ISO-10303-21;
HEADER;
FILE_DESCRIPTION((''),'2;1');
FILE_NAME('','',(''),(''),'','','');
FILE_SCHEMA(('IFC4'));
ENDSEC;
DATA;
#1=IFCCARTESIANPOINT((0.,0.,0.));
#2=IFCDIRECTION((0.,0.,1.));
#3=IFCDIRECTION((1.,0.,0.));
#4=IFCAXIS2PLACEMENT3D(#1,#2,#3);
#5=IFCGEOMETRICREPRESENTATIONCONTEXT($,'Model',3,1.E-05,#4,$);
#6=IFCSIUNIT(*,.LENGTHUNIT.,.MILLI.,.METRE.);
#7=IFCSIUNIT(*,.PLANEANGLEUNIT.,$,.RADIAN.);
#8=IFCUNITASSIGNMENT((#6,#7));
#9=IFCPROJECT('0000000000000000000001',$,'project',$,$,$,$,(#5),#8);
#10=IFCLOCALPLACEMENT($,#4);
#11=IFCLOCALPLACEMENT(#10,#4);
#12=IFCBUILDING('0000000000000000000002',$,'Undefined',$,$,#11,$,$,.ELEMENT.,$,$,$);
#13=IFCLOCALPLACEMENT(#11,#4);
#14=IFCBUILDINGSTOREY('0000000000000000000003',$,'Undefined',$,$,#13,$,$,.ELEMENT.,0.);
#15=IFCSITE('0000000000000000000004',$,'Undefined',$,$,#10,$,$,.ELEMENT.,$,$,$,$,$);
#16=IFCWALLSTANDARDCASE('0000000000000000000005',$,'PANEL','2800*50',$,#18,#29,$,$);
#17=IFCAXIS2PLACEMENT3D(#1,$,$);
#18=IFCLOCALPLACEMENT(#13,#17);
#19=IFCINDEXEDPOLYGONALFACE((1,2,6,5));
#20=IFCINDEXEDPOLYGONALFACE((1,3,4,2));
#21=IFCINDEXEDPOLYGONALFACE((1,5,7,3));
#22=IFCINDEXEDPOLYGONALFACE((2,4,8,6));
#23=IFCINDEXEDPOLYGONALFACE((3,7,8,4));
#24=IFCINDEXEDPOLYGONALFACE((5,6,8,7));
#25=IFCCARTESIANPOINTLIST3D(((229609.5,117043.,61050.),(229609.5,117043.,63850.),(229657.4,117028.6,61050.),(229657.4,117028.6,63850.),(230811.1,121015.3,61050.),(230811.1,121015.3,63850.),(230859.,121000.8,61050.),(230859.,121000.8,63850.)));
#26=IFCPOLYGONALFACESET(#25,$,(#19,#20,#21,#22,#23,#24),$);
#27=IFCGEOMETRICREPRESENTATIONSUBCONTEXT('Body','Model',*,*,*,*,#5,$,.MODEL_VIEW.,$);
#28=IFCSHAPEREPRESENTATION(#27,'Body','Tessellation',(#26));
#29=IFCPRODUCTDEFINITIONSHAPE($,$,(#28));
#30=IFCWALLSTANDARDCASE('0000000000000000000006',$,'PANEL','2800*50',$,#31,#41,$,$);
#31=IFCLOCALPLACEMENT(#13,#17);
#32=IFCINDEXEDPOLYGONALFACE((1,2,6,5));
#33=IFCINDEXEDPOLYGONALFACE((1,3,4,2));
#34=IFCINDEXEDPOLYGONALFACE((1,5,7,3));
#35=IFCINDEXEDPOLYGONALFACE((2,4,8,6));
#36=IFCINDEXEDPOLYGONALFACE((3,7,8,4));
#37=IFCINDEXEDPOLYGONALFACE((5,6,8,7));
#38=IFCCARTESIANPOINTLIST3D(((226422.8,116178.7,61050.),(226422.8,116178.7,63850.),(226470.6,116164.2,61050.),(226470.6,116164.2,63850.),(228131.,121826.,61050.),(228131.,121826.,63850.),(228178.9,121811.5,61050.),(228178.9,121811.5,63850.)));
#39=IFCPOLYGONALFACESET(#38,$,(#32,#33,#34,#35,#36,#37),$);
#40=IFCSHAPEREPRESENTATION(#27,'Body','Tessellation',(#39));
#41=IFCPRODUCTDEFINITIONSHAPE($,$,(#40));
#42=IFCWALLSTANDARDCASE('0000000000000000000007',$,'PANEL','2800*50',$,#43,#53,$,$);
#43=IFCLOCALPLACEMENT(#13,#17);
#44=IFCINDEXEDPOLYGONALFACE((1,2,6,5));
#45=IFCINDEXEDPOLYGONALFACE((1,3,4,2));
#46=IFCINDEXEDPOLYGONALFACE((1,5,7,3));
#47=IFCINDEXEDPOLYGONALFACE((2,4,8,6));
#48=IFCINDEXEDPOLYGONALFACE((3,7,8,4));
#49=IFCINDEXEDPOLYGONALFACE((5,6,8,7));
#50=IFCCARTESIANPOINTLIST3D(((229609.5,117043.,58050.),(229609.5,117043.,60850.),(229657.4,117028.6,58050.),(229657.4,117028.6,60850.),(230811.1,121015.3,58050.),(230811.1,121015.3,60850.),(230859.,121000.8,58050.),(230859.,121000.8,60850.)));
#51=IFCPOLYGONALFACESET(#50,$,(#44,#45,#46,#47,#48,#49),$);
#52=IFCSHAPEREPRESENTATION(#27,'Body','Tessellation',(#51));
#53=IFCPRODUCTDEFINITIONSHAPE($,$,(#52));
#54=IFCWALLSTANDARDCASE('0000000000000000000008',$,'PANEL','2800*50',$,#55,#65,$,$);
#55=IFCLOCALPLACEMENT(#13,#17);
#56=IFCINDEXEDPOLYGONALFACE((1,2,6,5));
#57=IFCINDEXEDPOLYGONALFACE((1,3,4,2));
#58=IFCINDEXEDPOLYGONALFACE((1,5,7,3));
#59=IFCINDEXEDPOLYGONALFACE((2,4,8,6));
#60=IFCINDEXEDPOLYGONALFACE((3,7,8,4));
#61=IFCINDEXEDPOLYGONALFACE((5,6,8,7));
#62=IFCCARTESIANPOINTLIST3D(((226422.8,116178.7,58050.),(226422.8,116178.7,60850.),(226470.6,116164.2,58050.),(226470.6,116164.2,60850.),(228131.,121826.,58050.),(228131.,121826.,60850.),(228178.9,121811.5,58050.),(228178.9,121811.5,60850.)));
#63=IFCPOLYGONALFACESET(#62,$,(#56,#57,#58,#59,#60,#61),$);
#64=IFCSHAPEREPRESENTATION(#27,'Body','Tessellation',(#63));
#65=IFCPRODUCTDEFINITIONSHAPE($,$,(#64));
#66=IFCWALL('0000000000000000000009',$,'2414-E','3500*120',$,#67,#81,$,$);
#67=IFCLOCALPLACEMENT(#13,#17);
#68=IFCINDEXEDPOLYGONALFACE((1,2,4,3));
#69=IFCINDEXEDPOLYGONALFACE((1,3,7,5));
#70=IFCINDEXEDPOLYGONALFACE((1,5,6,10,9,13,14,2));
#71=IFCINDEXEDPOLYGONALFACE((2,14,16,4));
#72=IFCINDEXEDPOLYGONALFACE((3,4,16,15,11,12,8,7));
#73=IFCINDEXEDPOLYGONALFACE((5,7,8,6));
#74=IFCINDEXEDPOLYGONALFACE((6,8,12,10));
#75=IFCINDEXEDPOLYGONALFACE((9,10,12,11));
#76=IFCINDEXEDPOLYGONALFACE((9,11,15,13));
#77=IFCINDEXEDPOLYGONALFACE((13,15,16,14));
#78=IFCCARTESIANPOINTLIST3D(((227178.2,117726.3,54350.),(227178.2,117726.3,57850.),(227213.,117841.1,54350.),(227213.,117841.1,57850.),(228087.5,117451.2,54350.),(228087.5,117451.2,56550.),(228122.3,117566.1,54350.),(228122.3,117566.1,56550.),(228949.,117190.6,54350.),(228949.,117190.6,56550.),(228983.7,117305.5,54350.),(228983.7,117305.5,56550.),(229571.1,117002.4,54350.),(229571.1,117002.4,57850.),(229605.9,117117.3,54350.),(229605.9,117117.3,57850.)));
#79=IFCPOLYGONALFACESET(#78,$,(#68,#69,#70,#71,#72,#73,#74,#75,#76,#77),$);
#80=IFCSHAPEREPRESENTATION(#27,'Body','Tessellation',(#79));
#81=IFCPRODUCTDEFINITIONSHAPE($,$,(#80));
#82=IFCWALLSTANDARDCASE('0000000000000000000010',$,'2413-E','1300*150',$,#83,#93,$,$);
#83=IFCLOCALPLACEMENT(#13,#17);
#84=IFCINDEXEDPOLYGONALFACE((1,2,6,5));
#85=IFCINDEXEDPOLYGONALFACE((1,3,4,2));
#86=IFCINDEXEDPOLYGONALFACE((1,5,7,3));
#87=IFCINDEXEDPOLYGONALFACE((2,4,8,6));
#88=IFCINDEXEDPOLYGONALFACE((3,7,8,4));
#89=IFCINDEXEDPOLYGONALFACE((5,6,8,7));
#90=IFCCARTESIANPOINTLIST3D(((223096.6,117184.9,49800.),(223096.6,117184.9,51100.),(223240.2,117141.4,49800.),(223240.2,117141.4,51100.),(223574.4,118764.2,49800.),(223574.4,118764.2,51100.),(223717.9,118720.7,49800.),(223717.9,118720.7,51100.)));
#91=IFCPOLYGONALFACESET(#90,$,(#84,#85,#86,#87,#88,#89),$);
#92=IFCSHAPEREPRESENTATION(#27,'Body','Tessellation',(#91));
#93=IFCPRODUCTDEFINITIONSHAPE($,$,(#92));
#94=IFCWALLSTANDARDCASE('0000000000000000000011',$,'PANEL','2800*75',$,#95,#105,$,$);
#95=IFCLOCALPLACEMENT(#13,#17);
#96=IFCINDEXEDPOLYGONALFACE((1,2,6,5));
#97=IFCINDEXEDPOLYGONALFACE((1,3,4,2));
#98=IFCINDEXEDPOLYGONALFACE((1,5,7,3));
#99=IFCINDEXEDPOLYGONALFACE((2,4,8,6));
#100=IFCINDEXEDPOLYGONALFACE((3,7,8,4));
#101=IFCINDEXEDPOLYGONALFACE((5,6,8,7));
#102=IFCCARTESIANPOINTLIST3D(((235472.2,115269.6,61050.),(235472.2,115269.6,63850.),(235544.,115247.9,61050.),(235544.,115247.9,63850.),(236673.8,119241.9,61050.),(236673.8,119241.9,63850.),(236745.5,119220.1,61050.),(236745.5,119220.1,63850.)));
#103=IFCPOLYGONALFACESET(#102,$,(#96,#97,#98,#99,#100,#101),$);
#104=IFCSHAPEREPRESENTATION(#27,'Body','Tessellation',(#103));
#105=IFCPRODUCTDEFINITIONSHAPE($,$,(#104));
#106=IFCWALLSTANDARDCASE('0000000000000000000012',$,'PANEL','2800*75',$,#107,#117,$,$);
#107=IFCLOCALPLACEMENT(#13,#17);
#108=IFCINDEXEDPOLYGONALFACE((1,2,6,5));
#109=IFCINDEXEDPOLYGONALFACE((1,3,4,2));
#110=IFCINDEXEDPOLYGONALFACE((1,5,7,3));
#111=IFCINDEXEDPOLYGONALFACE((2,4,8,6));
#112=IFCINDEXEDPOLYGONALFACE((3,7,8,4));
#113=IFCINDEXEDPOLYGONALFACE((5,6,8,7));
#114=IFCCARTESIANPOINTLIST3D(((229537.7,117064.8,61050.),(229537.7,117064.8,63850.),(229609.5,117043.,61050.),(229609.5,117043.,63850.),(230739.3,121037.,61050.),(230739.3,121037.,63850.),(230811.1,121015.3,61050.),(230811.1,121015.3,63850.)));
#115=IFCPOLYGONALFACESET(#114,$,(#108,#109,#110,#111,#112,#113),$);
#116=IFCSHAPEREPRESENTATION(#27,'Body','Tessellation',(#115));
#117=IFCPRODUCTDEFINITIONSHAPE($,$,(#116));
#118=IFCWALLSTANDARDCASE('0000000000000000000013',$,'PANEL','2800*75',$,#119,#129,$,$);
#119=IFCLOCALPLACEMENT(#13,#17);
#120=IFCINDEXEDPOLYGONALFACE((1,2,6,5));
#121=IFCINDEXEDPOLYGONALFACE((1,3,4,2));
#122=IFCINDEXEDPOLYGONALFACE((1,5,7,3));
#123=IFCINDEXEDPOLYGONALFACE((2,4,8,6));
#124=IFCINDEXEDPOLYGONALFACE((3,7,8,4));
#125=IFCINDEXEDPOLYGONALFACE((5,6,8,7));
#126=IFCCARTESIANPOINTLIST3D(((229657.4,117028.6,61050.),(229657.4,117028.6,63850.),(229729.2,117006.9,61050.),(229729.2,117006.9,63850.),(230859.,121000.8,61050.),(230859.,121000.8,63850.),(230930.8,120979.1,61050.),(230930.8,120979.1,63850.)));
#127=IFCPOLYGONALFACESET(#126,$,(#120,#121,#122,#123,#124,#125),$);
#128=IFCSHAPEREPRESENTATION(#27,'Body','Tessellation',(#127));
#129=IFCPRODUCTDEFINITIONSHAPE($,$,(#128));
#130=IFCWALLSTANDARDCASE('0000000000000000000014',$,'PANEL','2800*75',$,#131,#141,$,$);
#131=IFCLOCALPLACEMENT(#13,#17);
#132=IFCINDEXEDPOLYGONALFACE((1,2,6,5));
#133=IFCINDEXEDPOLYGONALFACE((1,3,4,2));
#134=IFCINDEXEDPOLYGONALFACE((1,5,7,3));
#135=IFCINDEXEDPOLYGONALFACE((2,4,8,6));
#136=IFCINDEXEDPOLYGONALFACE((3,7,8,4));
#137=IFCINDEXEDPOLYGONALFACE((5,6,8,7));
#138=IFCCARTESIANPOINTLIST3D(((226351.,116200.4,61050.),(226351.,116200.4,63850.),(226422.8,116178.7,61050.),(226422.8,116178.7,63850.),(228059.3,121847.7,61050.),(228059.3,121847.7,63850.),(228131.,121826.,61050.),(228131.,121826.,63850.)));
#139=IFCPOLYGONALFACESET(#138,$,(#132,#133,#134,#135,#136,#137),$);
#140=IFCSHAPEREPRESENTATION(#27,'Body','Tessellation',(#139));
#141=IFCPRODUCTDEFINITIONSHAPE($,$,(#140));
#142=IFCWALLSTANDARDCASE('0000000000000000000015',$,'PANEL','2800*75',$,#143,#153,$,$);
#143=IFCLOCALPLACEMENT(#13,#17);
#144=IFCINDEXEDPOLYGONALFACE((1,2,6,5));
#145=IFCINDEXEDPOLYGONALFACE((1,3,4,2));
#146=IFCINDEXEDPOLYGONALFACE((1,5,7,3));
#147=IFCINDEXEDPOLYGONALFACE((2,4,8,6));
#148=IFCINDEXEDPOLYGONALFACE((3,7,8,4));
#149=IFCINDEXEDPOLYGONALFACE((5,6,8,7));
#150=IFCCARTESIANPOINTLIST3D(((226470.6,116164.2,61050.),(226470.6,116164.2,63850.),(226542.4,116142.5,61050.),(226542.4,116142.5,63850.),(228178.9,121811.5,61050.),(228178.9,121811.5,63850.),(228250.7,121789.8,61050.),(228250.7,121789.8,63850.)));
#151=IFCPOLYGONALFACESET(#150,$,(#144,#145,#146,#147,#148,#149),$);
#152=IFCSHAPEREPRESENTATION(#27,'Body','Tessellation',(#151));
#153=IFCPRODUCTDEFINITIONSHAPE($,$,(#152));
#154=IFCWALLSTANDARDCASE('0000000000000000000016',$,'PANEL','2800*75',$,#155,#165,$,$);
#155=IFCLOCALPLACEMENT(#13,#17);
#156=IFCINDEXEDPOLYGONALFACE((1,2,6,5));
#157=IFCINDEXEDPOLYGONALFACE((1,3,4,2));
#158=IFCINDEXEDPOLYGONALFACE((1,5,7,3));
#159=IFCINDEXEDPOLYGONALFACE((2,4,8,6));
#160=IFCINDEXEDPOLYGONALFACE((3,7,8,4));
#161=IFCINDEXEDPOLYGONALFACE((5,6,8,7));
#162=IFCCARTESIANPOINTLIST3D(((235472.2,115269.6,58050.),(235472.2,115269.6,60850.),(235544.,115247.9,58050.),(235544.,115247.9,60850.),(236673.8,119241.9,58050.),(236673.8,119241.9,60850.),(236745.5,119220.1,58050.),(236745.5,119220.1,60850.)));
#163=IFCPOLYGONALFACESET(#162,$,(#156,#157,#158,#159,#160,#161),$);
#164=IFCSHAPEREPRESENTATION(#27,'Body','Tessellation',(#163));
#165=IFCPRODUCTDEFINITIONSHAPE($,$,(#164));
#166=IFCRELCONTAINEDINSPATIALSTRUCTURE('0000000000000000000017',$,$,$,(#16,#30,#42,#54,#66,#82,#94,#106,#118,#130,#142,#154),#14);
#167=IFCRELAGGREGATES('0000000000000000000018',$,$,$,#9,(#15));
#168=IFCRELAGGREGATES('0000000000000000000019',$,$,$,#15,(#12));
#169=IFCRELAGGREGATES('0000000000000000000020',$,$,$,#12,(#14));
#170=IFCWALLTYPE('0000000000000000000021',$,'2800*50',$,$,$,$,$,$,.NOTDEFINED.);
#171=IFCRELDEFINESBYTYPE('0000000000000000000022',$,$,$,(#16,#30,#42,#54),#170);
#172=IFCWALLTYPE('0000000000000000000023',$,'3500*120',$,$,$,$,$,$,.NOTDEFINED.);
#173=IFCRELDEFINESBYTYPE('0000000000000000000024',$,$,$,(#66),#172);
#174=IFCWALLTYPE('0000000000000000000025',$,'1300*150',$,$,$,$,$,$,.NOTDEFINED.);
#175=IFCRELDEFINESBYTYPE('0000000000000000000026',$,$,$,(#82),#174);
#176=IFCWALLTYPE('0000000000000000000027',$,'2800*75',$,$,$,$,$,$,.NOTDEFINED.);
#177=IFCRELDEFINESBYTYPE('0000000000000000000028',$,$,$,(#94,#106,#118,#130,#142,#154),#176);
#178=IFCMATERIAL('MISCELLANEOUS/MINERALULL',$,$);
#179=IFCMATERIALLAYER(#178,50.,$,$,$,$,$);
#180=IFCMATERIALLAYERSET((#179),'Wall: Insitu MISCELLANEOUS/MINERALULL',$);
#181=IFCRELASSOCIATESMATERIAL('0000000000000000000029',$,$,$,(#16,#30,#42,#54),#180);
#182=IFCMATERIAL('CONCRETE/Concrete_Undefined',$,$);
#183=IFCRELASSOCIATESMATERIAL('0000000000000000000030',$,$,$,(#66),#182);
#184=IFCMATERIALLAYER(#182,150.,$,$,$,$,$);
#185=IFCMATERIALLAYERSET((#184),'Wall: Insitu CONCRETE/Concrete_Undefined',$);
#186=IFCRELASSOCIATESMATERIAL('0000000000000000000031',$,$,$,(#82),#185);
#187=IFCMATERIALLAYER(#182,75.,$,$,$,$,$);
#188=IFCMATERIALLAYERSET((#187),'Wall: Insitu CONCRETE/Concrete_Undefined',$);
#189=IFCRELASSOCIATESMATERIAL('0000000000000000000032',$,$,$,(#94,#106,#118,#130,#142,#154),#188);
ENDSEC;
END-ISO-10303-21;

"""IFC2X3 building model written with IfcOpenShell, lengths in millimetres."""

from ifc_helpers import new_model, si_unit, frame, frame_2d, origin_with_axes, place, context, subcontext, project, spatial, rectangle, extrude, boolean, material, layer, layer_set, layer_usage, type_object, element, save


model = new_model("IFC2X3")

# Units and contexts
model_context = context("Model", 3, precision=1e-05, world=origin_with_axes())
body_context = subcontext(model_context, "Body", "Model", "MODEL_VIEW")
ifc_project = project(units=[si_unit("LENGTHUNIT", "METRE", prefix="MILLI"), si_unit("PLANEANGLEUNIT", "RADIAN")], contexts=[model_context])

# Site, building, storey
site_placement = place(None, origin_with_axes())
site = spatial("IfcSite", under=ifc_project, at=site_placement, Name="Undefined", CompositionType="ELEMENT")
building_placement = place(site_placement, origin_with_axes())
building = spatial("IfcBuilding", under=site, at=building_placement, Name="Undefined", CompositionType="ELEMENT")
storey_placement = place(building_placement, origin_with_axes())
storey = spatial("IfcBuildingStorey", under=building, at=storey_placement, Name="Undefined", CompositionType="ELEMENT", Elevation=0.0)

# Walls
ifc_material_1 = material(Name="CONCRETE/Concrete_Undefined")
ifc_layer_1 = layer(ifc_material_1, 150.0)
ifc_layer_set_1 = layer_set([ifc_layer_1], Name="Wall: Insitu CONCRETE/Concrete_Undefined")
ifc_material_2 = material(Name="MISCELLANEOUS/MINERALULL")
ifc_layer_2 = layer(ifc_material_2, 50.0)
ifc_layer_set_2 = layer_set([ifc_layer_2], Name="Wall: Insitu MISCELLANEOUS/MINERALULL")
ifc_layer_usage_1 = layer_usage(ifc_layer_set_2, "AXIS2", "POSITIVE", -25.0)
wall_type_1 = type_object("IfcWallType", Name="2800*50", PredefinedType="NOTDEFINED")
wall_1_placement = place(storey_placement, frame((229633.5, 117035.8, 61050.0), z_axis=(0.0, 0.0, 1.0), x_axis=(0.289537, 0.957167, 0.0)))
element("IfcWallStandardCase", 1, at=wall_1_placement, inside=storey, type_object=wall_type_1, material=ifc_layer_usage_1, Name="PANEL", Description="2800*50", context=body_context, shape_type="SweptSolid", body=[
    extrude(rectangle(XDim=4150.0, YDim=50.0, at=frame_2d((0.0, 2075.0), x_axis=(0.0, -1.0))), frame((0.0, 0.0, 0.0), z_axis=(0.0, 0.0, 1.0), x_axis=(0.0, -1.0, 0.0)), (0.0, 0.0, 1.0), 2800.0),
])
ifc_layer_usage_2 = layer_usage(ifc_layer_set_2, "AXIS2", "POSITIVE", -25.0)
wall_2_placement = place(storey_placement, frame((226446.7, 116171.5, 61050.0), z_axis=(0.0, 0.0, 1.0), x_axis=(0.289537, 0.957167, 0.0)))
element("IfcWallStandardCase", 2, at=wall_2_placement, inside=storey, type_object=wall_type_1, material=ifc_layer_usage_2, Name="PANEL", Description="2800*50", context=body_context, shape_type="SweptSolid", body=[
    extrude(rectangle(XDim=5900.0, YDim=50.0, at=frame_2d((0.0, 2950.0), x_axis=(0.0, -1.0))), frame((0.0, 0.0, 0.0), z_axis=(0.0, 0.0, 1.0), x_axis=(0.0, -1.0, 0.0)), (0.0, 0.0, 1.0), 2800.0),
])
ifc_layer_usage_3 = layer_usage(ifc_layer_set_2, "AXIS2", "POSITIVE", -25.0)
wall_3_placement = place(storey_placement, frame((229633.5, 117035.8, 58050.0), z_axis=(0.0, 0.0, 1.0), x_axis=(0.289537, 0.957167, 0.0)))
element("IfcWallStandardCase", 3, at=wall_3_placement, inside=storey, type_object=wall_type_1, material=ifc_layer_usage_3, Name="PANEL", Description="2800*50", context=body_context, shape_type="SweptSolid", body=[
    extrude(rectangle(XDim=4150.0, YDim=50.0, at=frame_2d((0.0, 2075.0), x_axis=(0.0, -1.0))), frame((0.0, 0.0, 0.0), z_axis=(0.0, 0.0, 1.0), x_axis=(0.0, -1.0, 0.0)), (0.0, 0.0, 1.0), 2800.0),
])
ifc_layer_usage_4 = layer_usage(ifc_layer_set_2, "AXIS2", "POSITIVE", -25.0)
wall_4_placement = place(storey_placement, frame((226446.7, 116171.5, 58050.0), z_axis=(0.0, 0.0, 1.0), x_axis=(0.289537, 0.957167, 0.0)))
element("IfcWallStandardCase", 4, at=wall_4_placement, inside=storey, type_object=wall_type_1, material=ifc_layer_usage_4, Name="PANEL", Description="2800*50", context=body_context, shape_type="SweptSolid", body=[
    extrude(rectangle(XDim=5900.0, YDim=50.0, at=frame_2d((0.0, 2950.0), x_axis=(0.0, -1.0))), frame((0.0, 0.0, 0.0), z_axis=(0.0, 0.0, 1.0), x_axis=(0.0, -1.0, 0.0)), (0.0, 0.0, 1.0), 2800.0),
])
wall_type_2 = type_object("IfcWallType", Name="3500*120", PredefinedType="NOTDEFINED")
wall_5_placement = place(storey_placement, frame((229588.5, 117059.9, 54350.0), z_axis=(0.0, 0.0, 1.0), x_axis=(-0.957166, 0.289539, 0.0)))
element("IfcWall", 5, at=wall_5_placement, inside=storey, type_object=wall_type_2, material=ifc_material_1, Name="2414-E", Description="3500*120", context=body_context, shape_type="CSG", body=[
    boolean("DIFFERENCE", extrude(rectangle(XDim=2500.0, YDim=120.0, at=frame_2d((0.0, 1250.0), x_axis=(0.0, -1.0))), frame((0.0, 0.0, 0.0), z_axis=(0.0, 0.0, 1.0), x_axis=(0.0, -1.0, 0.0)), (0.0, 0.0, 1.0), 3500.0), extrude(rectangle(XDim=900.0, YDim=150.0, at=frame_2d((0.0, 450.0), x_axis=(0.0, -1.0))), frame((650.0, -15.0, 0.0), z_axis=(0.0, 0.0, 1.0), x_axis=(-0.000003, -1.0, 0.0)), (0.0, 0.0, 1.0), 2200.0)),
])
ifc_layer_usage_5 = layer_usage(ifc_layer_set_1, "AXIS2", "POSITIVE", -75.0)
wall_type_3 = type_object("IfcWallType", Name="1300*150", PredefinedType="NOTDEFINED")
wall_6_placement = place(storey_placement, frame((223646.1, 118742.5, 49800.0), z_axis=(0.0, 0.0, 1.0), x_axis=(-0.289535, -0.957167, 0.0)))
element("IfcWallStandardCase", 6, at=wall_6_placement, inside=storey, type_object=wall_type_3, material=ifc_layer_usage_5, Name="2413-E", Description="1300*150", context=body_context, shape_type="SweptSolid", body=[
    extrude(rectangle(XDim=1650.0, YDim=150.0, at=frame_2d((0.0, 825.0), x_axis=(0.0, -1.0))), frame((0.0, 0.0, 0.0), z_axis=(0.0, 0.0, 1.0), x_axis=(0.0, -1.0, 0.0)), (0.0, 0.0, 1.0), 1300.0),
])
ifc_layer_3 = layer(ifc_material_1, 75.0)
ifc_layer_set_3 = layer_set([ifc_layer_3], Name="Wall: Insitu CONCRETE/Concrete_Undefined")
ifc_layer_usage_6 = layer_usage(ifc_layer_set_3, "AXIS2", "POSITIVE", -37.5)
wall_type_4 = type_object("IfcWallType", Name="2800*75", PredefinedType="NOTDEFINED")
wall_7_placement = place(storey_placement, frame((235508.1, 115258.8, 61050.0), z_axis=(0.0, 0.0, 1.0), x_axis=(0.289537, 0.957167, 0.0)))
element("IfcWallStandardCase", 7, at=wall_7_placement, inside=storey, type_object=wall_type_4, material=ifc_layer_usage_6, Name="PANEL", Description="2800*75", context=body_context, shape_type="SweptSolid", body=[
    extrude(rectangle(XDim=4150.0, YDim=75.0, at=frame_2d((0.0, 2075.0), x_axis=(0.0, -1.0))), frame((0.0, 0.0, 0.0), z_axis=(0.0, 0.0, 1.0), x_axis=(0.0, -1.0, 0.0)), (0.0, 0.0, 1.0), 2800.0),
])
ifc_layer_usage_7 = layer_usage(ifc_layer_set_3, "AXIS2", "POSITIVE", -37.5)
wall_8_placement = place(storey_placement, frame((229573.6, 117053.9, 61050.0), z_axis=(0.0, 0.0, 1.0), x_axis=(0.289537, 0.957167, 0.0)))
element("IfcWallStandardCase", 8, at=wall_8_placement, inside=storey, type_object=wall_type_4, material=ifc_layer_usage_7, Name="PANEL", Description="2800*75", context=body_context, shape_type="SweptSolid", body=[
    extrude(rectangle(XDim=4150.0, YDim=75.0, at=frame_2d((0.0, 2075.0), x_axis=(0.0, -1.0))), frame((0.0, 0.0, 0.0), z_axis=(0.0, 0.0, 1.0), x_axis=(0.0, -1.0, 0.0)), (0.0, 0.0, 1.0), 2800.0),
])
ifc_layer_usage_8 = layer_usage(ifc_layer_set_3, "AXIS2", "POSITIVE", -37.5)
wall_9_placement = place(storey_placement, frame((229693.3, 117017.7, 61050.0), z_axis=(0.0, 0.0, 1.0), x_axis=(0.289537, 0.957167, 0.0)))
element("IfcWallStandardCase", 9, at=wall_9_placement, inside=storey, type_object=wall_type_4, material=ifc_layer_usage_8, Name="PANEL", Description="2800*75", context=body_context, shape_type="SweptSolid", body=[
    extrude(rectangle(XDim=4150.0, YDim=75.0, at=frame_2d((0.0, 2075.0), x_axis=(0.0, -1.0))), frame((0.0, 0.0, 0.0), z_axis=(0.0, 0.0, 1.0), x_axis=(0.0, -1.0, 0.0)), (0.0, 0.0, 1.0), 2800.0),
])
ifc_layer_usage_9 = layer_usage(ifc_layer_set_3, "AXIS2", "POSITIVE", -37.5)
wall_10_placement = place(storey_placement, frame((226386.9, 116189.6, 61050.0), z_axis=(0.0, 0.0, 1.0), x_axis=(0.289537, 0.957167, 0.0)))
element("IfcWallStandardCase", 10, at=wall_10_placement, inside=storey, type_object=wall_type_4, material=ifc_layer_usage_9, Name="PANEL", Description="2800*75", context=body_context, shape_type="SweptSolid", body=[
    extrude(rectangle(XDim=5900.0, YDim=75.0, at=frame_2d((0.0, 2950.0), x_axis=(0.0, -1.0))), frame((0.0, 0.0, 0.0), z_axis=(0.0, 0.0, 1.0), x_axis=(0.0, -1.0, 0.0)), (0.0, 0.0, 1.0), 2800.0),
])
ifc_layer_usage_10 = layer_usage(ifc_layer_set_3, "AXIS2", "POSITIVE", -37.5)
wall_11_placement = place(storey_placement, frame((226506.5, 116153.4, 61050.0), z_axis=(0.0, 0.0, 1.0), x_axis=(0.289537, 0.957167, 0.0)))
element("IfcWallStandardCase", 11, at=wall_11_placement, inside=storey, type_object=wall_type_4, material=ifc_layer_usage_10, Name="PANEL", Description="2800*75", context=body_context, shape_type="SweptSolid", body=[
    extrude(rectangle(XDim=5900.0, YDim=75.0, at=frame_2d((0.0, 2950.0), x_axis=(0.0, -1.0))), frame((0.0, 0.0, 0.0), z_axis=(0.0, 0.0, 1.0), x_axis=(0.0, -1.0, 0.0)), (0.0, 0.0, 1.0), 2800.0),
])
ifc_layer_usage_11 = layer_usage(ifc_layer_set_3, "AXIS2", "POSITIVE", -37.5)
wall_12_placement = place(storey_placement, frame((235508.1, 115258.8, 58050.0), z_axis=(0.0, 0.0, 1.0), x_axis=(0.289537, 0.957167, 0.0)))
element("IfcWallStandardCase", 12, at=wall_12_placement, inside=storey, type_object=wall_type_4, material=ifc_layer_usage_11, Name="PANEL", Description="2800*75", context=body_context, shape_type="SweptSolid", body=[
    extrude(rectangle(XDim=4150.0, YDim=75.0, at=frame_2d((0.0, 2075.0), x_axis=(0.0, -1.0))), frame((0.0, 0.0, 0.0), z_axis=(0.0, 0.0, 1.0), x_axis=(0.0, -1.0, 0.0)), (0.0, 0.0, 1.0), 2800.0),
])

save(model, "model.ifc")
